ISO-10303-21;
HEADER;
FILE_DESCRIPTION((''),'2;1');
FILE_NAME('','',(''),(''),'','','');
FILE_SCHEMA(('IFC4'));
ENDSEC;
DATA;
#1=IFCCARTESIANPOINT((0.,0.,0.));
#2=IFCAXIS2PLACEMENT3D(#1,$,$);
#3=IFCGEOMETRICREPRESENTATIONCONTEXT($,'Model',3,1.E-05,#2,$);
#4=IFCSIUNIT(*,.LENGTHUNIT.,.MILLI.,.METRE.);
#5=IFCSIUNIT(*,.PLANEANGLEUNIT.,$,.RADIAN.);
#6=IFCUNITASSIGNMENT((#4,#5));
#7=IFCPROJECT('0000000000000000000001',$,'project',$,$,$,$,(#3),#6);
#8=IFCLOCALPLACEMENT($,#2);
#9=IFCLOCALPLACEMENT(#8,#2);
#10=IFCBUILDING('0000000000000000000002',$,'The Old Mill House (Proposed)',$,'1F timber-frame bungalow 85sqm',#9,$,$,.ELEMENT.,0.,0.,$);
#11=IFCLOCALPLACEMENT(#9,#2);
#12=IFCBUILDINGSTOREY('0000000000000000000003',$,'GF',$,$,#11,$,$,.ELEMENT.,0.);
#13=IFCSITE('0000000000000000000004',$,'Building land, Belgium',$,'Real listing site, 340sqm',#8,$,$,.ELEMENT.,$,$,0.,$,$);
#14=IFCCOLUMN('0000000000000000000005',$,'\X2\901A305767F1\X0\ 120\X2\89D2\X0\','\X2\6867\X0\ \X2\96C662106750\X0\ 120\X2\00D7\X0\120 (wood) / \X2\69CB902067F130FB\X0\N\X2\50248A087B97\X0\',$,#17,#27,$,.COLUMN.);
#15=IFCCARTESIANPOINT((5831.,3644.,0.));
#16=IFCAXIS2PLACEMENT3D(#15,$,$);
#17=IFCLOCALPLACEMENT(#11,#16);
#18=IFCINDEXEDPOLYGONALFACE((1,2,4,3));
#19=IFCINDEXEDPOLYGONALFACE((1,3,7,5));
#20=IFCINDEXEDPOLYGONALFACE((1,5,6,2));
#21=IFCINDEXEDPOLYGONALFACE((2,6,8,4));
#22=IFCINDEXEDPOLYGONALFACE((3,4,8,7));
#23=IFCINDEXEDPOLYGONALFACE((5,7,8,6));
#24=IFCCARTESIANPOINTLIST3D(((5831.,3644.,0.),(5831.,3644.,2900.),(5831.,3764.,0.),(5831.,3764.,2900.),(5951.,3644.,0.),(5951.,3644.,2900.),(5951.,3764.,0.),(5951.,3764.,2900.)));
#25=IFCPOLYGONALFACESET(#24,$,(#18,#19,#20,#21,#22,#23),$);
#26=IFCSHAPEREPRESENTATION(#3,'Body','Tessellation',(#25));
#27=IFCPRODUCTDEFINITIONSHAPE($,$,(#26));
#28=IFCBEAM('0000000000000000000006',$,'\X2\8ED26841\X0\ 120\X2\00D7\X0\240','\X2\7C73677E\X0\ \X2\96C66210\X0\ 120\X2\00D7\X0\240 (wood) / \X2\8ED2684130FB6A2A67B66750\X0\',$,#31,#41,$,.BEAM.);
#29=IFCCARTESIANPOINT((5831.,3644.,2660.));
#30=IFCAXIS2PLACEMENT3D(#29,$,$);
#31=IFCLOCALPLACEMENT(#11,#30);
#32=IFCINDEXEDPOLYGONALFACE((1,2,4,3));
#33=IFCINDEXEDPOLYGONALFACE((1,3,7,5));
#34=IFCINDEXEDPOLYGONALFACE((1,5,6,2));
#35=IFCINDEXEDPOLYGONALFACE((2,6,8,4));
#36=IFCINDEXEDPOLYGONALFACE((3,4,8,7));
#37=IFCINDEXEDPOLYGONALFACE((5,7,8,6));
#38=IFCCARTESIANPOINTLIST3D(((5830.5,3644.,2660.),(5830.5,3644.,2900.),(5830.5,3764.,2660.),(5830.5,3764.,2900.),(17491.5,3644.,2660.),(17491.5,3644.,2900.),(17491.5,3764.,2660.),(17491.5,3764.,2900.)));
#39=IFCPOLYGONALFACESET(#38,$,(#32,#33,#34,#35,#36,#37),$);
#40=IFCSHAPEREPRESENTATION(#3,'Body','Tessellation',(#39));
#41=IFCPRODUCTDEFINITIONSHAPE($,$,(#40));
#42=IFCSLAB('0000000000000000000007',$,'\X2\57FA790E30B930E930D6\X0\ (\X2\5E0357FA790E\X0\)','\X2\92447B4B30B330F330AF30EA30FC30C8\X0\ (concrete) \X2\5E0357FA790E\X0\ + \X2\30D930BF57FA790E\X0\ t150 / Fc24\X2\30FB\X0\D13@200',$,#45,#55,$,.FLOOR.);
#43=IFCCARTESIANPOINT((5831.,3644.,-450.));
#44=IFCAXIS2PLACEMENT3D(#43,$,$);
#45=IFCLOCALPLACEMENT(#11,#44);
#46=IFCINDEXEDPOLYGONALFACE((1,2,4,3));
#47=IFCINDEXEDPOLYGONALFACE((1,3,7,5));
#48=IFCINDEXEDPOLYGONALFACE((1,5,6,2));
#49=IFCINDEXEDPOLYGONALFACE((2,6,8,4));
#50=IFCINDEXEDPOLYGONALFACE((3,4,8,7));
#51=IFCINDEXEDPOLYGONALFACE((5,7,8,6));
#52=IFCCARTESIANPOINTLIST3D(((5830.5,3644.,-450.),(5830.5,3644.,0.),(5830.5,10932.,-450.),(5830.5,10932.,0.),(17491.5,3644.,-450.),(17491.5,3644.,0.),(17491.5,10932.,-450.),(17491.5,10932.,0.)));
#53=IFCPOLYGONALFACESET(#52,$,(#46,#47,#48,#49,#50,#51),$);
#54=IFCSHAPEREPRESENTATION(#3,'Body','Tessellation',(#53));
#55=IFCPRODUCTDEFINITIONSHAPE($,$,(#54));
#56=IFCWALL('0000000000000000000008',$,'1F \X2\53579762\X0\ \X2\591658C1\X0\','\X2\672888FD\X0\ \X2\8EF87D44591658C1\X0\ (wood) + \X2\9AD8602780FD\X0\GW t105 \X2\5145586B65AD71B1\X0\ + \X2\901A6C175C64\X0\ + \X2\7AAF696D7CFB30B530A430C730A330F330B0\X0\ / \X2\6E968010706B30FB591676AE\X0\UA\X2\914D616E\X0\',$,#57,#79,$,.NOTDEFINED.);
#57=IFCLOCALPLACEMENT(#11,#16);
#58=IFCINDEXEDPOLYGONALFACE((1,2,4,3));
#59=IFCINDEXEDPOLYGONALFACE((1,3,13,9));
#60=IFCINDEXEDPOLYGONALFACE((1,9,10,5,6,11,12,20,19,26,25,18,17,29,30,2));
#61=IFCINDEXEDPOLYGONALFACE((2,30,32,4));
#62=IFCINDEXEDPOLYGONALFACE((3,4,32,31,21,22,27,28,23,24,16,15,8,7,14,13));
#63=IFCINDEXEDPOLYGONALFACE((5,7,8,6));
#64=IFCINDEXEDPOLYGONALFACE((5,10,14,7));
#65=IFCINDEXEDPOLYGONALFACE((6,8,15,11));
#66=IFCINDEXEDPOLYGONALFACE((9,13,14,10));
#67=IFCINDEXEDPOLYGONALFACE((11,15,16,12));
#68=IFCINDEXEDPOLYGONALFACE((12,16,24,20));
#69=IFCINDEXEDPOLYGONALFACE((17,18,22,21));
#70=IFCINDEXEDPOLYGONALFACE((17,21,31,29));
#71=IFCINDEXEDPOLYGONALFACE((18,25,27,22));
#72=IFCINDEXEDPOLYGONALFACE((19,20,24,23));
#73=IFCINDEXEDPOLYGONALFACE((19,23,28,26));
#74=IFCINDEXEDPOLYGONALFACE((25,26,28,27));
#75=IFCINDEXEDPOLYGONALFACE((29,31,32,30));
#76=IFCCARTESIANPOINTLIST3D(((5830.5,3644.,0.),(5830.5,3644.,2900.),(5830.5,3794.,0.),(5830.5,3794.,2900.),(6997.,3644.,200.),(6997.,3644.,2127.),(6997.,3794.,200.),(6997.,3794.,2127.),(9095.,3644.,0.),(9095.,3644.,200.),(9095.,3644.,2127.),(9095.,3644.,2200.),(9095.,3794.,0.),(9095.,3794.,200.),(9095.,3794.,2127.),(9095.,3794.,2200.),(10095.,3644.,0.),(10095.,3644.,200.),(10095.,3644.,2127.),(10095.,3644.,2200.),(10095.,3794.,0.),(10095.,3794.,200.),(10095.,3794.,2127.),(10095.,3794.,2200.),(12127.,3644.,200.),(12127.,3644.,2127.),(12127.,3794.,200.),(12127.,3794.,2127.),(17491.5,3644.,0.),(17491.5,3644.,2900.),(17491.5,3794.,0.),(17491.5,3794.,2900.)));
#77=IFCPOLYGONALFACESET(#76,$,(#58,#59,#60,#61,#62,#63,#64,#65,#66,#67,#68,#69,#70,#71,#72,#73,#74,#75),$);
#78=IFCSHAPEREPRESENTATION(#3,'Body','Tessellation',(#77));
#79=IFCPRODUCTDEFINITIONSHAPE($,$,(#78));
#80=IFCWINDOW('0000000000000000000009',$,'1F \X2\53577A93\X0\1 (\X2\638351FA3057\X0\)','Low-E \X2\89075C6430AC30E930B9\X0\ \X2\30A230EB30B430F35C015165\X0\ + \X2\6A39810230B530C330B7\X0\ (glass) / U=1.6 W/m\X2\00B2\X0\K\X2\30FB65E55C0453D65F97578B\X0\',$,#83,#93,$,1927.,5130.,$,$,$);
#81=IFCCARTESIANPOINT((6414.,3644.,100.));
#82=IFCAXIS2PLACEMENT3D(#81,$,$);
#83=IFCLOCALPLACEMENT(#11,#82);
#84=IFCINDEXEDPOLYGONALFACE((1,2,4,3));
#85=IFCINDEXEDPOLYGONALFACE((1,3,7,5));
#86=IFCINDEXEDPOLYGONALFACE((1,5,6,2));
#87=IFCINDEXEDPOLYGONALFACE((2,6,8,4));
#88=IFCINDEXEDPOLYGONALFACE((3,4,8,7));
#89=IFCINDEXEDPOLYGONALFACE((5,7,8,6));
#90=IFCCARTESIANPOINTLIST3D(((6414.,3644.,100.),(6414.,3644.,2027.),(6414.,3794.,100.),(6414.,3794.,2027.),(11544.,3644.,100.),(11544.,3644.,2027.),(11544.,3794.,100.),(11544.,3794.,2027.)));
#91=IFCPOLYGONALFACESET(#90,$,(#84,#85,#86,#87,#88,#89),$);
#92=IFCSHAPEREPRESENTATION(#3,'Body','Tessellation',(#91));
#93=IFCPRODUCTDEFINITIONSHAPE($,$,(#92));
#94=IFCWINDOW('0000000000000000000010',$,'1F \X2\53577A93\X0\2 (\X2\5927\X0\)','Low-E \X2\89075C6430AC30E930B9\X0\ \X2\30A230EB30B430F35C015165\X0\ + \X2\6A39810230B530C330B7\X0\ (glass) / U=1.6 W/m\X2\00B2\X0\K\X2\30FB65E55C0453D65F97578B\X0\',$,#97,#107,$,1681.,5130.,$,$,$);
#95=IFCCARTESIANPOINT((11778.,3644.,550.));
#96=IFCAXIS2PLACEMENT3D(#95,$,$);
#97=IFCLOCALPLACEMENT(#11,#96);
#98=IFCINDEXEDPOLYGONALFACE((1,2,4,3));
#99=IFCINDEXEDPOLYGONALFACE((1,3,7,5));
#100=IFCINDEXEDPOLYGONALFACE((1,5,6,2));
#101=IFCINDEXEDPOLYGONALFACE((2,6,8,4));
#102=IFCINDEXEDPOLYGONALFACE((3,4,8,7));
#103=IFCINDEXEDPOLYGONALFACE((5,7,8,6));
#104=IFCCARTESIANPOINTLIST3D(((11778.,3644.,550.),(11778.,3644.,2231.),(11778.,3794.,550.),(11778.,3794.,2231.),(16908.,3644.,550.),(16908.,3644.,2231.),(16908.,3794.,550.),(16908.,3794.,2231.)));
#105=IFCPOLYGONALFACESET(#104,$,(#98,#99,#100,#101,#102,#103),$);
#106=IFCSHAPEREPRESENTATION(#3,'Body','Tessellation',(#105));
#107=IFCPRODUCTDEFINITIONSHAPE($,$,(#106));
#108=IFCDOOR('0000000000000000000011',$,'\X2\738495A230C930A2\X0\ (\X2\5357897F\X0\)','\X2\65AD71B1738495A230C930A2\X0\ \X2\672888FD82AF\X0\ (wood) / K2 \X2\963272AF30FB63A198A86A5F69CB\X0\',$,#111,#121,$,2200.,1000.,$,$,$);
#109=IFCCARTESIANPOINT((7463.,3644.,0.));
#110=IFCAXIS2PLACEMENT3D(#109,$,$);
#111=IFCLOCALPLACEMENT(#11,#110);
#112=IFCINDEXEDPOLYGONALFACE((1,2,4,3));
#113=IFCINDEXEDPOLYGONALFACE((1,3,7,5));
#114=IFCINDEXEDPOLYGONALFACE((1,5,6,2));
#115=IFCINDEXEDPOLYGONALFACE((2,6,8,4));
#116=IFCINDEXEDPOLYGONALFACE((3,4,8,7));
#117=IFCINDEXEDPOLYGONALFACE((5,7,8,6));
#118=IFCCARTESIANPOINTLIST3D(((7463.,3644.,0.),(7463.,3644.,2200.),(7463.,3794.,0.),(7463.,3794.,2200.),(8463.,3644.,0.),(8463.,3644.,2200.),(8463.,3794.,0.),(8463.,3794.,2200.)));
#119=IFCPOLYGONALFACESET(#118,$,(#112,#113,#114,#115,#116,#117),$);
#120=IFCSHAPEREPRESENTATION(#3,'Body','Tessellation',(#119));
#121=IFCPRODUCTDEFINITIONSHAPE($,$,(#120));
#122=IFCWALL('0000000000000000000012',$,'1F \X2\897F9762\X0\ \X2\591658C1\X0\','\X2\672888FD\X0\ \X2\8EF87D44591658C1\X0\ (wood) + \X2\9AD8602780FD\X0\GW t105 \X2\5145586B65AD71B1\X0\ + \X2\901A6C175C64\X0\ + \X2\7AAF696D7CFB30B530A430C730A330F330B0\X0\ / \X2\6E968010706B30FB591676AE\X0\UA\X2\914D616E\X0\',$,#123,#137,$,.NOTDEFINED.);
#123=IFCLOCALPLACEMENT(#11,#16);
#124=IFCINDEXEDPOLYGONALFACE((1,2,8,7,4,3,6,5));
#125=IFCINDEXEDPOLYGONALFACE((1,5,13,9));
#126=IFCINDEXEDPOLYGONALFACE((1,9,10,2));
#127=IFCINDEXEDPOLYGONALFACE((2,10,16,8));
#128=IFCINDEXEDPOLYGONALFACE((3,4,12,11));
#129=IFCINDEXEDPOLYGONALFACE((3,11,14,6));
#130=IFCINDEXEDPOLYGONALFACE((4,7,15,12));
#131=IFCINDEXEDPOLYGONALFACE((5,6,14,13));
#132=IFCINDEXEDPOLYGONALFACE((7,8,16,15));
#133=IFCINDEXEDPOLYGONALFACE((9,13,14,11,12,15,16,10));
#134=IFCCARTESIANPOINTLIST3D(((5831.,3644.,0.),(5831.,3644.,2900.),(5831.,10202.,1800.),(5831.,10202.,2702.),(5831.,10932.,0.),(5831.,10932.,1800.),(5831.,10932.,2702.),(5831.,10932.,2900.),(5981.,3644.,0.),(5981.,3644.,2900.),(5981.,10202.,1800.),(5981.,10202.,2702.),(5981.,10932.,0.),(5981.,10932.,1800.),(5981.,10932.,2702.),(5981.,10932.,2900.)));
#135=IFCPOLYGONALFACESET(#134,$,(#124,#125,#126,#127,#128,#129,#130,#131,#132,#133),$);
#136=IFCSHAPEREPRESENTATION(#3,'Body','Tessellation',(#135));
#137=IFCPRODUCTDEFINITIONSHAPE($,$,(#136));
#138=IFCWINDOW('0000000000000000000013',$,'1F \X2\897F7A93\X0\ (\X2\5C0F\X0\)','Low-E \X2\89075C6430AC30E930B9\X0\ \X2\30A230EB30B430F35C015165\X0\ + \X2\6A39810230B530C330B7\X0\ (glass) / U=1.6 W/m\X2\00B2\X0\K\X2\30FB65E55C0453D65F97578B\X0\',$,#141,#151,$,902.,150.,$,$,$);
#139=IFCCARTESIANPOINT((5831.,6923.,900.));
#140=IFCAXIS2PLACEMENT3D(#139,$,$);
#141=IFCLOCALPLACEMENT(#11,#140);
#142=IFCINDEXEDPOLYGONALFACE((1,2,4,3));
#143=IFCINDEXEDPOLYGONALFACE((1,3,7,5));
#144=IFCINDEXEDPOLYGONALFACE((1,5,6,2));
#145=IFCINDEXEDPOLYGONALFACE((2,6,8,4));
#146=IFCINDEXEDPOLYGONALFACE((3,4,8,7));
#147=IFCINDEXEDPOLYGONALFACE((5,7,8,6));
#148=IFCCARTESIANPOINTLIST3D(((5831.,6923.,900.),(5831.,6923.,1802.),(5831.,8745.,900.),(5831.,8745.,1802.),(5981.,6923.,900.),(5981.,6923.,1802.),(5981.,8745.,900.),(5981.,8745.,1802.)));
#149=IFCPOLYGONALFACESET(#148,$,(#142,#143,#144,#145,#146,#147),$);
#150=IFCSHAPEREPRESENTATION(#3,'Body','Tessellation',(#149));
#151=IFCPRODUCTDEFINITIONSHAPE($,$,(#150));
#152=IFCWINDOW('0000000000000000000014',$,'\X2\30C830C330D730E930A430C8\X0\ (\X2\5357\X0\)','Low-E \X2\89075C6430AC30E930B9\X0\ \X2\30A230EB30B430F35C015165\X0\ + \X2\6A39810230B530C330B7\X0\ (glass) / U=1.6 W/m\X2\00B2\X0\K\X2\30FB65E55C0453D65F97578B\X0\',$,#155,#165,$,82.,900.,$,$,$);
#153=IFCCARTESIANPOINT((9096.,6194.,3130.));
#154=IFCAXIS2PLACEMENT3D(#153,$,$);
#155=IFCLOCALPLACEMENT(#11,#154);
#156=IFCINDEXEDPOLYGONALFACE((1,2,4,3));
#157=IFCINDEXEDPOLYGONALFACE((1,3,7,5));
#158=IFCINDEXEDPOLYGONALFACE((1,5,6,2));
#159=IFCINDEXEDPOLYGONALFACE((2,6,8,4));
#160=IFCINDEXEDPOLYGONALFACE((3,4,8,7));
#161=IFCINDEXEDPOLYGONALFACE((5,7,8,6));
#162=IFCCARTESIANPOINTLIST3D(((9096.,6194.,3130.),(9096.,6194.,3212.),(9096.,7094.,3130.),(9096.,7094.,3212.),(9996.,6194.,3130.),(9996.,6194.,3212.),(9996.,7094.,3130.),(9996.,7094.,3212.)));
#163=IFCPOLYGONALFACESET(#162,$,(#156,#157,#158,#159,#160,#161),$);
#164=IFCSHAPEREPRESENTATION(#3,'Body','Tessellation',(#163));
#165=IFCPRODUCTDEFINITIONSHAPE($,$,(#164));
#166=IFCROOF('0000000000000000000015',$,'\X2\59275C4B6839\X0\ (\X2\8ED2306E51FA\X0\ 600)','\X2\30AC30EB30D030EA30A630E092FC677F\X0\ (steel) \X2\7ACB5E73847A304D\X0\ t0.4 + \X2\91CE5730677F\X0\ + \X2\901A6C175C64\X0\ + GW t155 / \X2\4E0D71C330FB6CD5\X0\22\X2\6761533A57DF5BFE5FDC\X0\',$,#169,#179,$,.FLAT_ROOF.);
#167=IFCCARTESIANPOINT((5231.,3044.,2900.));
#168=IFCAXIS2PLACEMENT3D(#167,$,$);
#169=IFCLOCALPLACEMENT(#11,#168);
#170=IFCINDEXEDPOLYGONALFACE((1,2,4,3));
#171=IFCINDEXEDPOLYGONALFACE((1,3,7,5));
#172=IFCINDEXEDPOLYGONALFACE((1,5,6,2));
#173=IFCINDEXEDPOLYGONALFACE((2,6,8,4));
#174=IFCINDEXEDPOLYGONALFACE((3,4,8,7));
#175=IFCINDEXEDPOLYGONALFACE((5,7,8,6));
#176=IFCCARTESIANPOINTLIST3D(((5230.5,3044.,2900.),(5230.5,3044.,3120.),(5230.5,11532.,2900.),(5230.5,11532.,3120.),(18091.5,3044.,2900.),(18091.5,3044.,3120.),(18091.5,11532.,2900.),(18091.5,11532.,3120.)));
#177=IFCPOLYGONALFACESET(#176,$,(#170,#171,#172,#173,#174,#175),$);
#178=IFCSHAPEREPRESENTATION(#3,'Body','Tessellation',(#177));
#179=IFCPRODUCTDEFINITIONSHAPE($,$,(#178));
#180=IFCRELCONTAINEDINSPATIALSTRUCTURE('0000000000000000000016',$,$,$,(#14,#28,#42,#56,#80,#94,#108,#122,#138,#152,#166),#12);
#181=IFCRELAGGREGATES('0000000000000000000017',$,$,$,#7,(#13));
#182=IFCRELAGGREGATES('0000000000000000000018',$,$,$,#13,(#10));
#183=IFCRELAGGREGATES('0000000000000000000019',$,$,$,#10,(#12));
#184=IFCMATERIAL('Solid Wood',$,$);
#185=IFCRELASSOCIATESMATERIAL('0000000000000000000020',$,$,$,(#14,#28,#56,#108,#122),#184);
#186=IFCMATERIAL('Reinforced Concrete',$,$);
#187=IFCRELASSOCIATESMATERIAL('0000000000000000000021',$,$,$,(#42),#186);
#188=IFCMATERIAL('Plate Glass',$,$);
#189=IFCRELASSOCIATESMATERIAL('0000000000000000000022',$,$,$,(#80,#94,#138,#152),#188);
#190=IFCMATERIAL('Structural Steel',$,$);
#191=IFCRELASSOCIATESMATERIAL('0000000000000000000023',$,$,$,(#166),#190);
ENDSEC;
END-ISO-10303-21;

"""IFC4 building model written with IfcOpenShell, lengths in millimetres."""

from ifc_helpers import new_model, si_unit, frame, frame_2d, origin, place, context, project, spatial, rectangle, extrude, material, element, fill, save


model = new_model("IFC4")

# Units and contexts
model_context = context("Model", 3, precision=1e-05, world=origin())
ifc_project = project(units=[si_unit("LENGTHUNIT", "METRE", prefix="MILLI"), si_unit("PLANEANGLEUNIT", "RADIAN")], contexts=[model_context])

# Site, building, storey
site_placement = place(None, origin())
site = spatial("IfcSite", under=ifc_project, at=site_placement, Name="Building land, Belgium", ObjectType="Real listing site, 340sqm", CompositionType="ELEMENT", RefElevation=0.0)
building_placement = place(site_placement, origin())
building = spatial("IfcBuilding", under=site, at=building_placement, Name="The Old Mill House (Proposed)", ObjectType="1F timber-frame bungalow 85sqm", CompositionType="ELEMENT", ElevationOfRefHeight=0.0, ElevationOfTerrain=0.0)
storey_placement = place(building_placement, origin())
storey = spatial("IfcBuildingStorey", under=building, at=storey_placement, Name="GF", CompositionType="ELEMENT", Elevation=0.0)

# Column
ifc_material_1 = material(Name="Solid Wood")
column_1_placement = place(storey_placement, frame((5831.0, 3644.0, 0.0)))
element("IfcColumn", 1, at=column_1_placement, inside=storey, material=ifc_material_1, Name="通し柱 120角", Description="桧 集成材 120×120 (wood) / 構造柱・N値計算", PredefinedType="COLUMN", context=model_context, shape_type="SweptSolid", body=[
    extrude(rectangle(XDim=120.0, YDim=120.0, at=frame_2d((60.0, 60.0))), frame((5831.0, 3644.0, 0.0)), (0.0, 0.0, 1.0), 2900.0),
])

# Beam
beam_1_placement = place(storey_placement, frame((5831.0, 3644.0, 2660.0)))
element("IfcBeam", 2, at=beam_1_placement, inside=storey, material=ifc_material_1, Name="軒桁 120×240", Description="米松 集成 120×240 (wood) / 軒桁・横架材", PredefinedType="BEAM", context=model_context, shape_type="SweptSolid", body=[
    extrude(rectangle(XDim=11661.0, YDim=120.0, at=frame_2d((5830.0, 60.0))), frame((5831.0, 3644.0, 2660.0)), (0.0, 0.0, 1.0), 240.0),
])

# Slab
ifc_material_2 = material(Name="Reinforced Concrete")
slab_1_placement = place(storey_placement, frame((5831.0, 3644.0, -450.0)))
element("IfcSlab", 3, at=slab_1_placement, inside=storey, material=ifc_material_2, Name="基礎スラブ (布基礎)", Description="鉄筋コンクリート (concrete) 布基礎 + ベタ基礎 t150 / Fc24・D13@200", PredefinedType="FLOOR", context=model_context, shape_type="SweptSolid", body=[
    extrude(rectangle(XDim=11661.0, YDim=7288.0, at=frame_2d((5830.0, 3644.0))), frame((5831.0, 3644.0, -450.0)), (0.0, 0.0, 1.0), 450.0),
])

# Wall, openings, windows, door
wall_1_placement = place(storey_placement, frame((5831.0, 3644.0, 0.0)))
wall_1 = element("IfcWall", 4, at=wall_1_placement, inside=storey, material=ifc_material_1, Name="1F 南面 外壁", Description="木製 軸組外壁 (wood) + 高性能GW t105 充填断熱 + 通気層 + 窯業系サイディング / 準耐火・外皮UA配慮", PredefinedType="NOTDEFINED", context=model_context, shape_type="SweptSolid", body=[
    extrude(rectangle(XDim=11661.0, YDim=150.0, at=frame_2d((5830.0, 75.0))), frame((5831.0, 3644.0, 0.0)), (0.0, 0.0, 1.0), 2900.0),
])
opening_1_placement = place(storey_placement, frame((6414.0, 3644.0, 100.0)))
opening_1 = element("IfcOpeningElement", 5, at=opening_1_placement, cuts=wall_1, PredefinedType="NOTDEFINED", context=model_context, shape_type="SweptSolid", body=[
    extrude(rectangle(XDim=5130.0, YDim=150.0, at=frame_2d((2565.0, 75.0))), frame((6414.0, 3644.0, 100.0)), (0.0, 0.0, 1.0), 1927.0),
])
opening_2_placement = place(storey_placement, frame((11778.0, 3644.0, 550.0)))
opening_2 = element("IfcOpeningElement", 6, at=opening_2_placement, cuts=wall_1, PredefinedType="NOTDEFINED", context=model_context, shape_type="SweptSolid", body=[
    extrude(rectangle(XDim=5130.0, YDim=150.0, at=frame_2d((2565.0, 75.0))), frame((11778.0, 3644.0, 550.0)), (0.0, 0.0, 1.0), 1681.0),
])
opening_3_placement = place(storey_placement, frame((7463.0, 3644.0, 0.0)))
opening_3 = element("IfcOpeningElement", 7, at=opening_3_placement, cuts=wall_1, PredefinedType="NOTDEFINED", context=model_context, shape_type="SweptSolid", body=[
    extrude(rectangle(XDim=1000.0, YDim=150.0, at=frame_2d((500.0, 75.0))), frame((7463.0, 3644.0, 0.0)), (0.0, 0.0, 1.0), 2200.0),
])
ifc_material_3 = material(Name="Plate Glass")
window_1_placement = place(storey_placement, frame((6414.0, 3644.0, 100.0)))
window_1 = element("IfcWindow", 8, at=window_1_placement, inside=storey, material=ifc_material_3, Name="1F 南窓1 (掃出し)", Description="Low-E 複層ガラス アルゴン封入 + 樹脂サッシ (glass) / U=1.6 W/m²K・日射取得型", OverallHeight=1927.0, OverallWidth=5130.0, context=model_context, shape_type="SweptSolid", body=[
    extrude(rectangle(XDim=5130.0, YDim=150.0, at=frame_2d((2565.0, 75.0))), frame((6414.0, 3644.0, 100.0)), (0.0, 0.0, 1.0), 1927.0),
])
fill(opening_1, window_1)
window_2_placement = place(storey_placement, frame((11778.0, 3644.0, 550.0)))
window_2 = element("IfcWindow", 9, at=window_2_placement, inside=storey, material=ifc_material_3, Name="1F 南窓2 (大)", Description="Low-E 複層ガラス アルゴン封入 + 樹脂サッシ (glass) / U=1.6 W/m²K・日射取得型", OverallHeight=1681.0, OverallWidth=5130.0, context=model_context, shape_type="SweptSolid", body=[
    extrude(rectangle(XDim=5130.0, YDim=150.0, at=frame_2d((2565.0, 75.0))), frame((11778.0, 3644.0, 550.0)), (0.0, 0.0, 1.0), 1681.0),
])
fill(opening_2, window_2)
door_placement = place(storey_placement, frame((7463.0, 3644.0, 0.0)))
door = element("IfcDoor", 10, at=door_placement, inside=storey, material=ifc_material_1, Name="玄関ドア (南西)", Description="断熱玄関ドア 木製芯 (wood) / K2 防犯・採風機構", OverallHeight=2200.0, OverallWidth=1000.0, context=model_context, shape_type="SweptSolid", body=[
    extrude(rectangle(XDim=1000.0, YDim=150.0, at=frame_2d((500.0, 75.0))), frame((7463.0, 3644.0, 0.0)), (0.0, 0.0, 1.0), 2200.0),
])
fill(opening_3, door)

# Wall, opening, window
wall_2_placement = place(storey_placement, frame((5831.0, 3644.0, 0.0)))
wall_2 = element("IfcWall", 11, at=wall_2_placement, inside=storey, material=ifc_material_1, Name="1F 西面 外壁", Description="木製 軸組外壁 (wood) + 高性能GW t105 充填断熱 + 通気層 + 窯業系サイディング / 準耐火・外皮UA配慮", PredefinedType="NOTDEFINED", context=model_context, shape_type="SweptSolid", body=[
    extrude(rectangle(XDim=150.0, YDim=7288.0, at=frame_2d((75.0, 3644.0))), frame((5831.0, 3644.0, 0.0)), (0.0, 0.0, 1.0), 2900.0),
])
opening_4_placement = place(storey_placement, frame((5831.0, 6923.0, 900.0)))
opening_4 = element("IfcOpeningElement", 12, at=opening_4_placement, cuts=wall_2, PredefinedType="NOTDEFINED", context=model_context, shape_type="SweptSolid", body=[
    extrude(rectangle(XDim=150.0, YDim=1822.0, at=frame_2d((75.0, 911.0))), frame((5831.0, 6923.0, 900.0)), (0.0, 0.0, 1.0), 902.0),
])
window_3_placement = place(storey_placement, frame((5831.0, 6923.0, 900.0)))
window_3 = element("IfcWindow", 13, at=window_3_placement, inside=storey, material=ifc_material_3, Name="1F 西窓 (小)", Description="Low-E 複層ガラス アルゴン封入 + 樹脂サッシ (glass) / U=1.6 W/m²K・日射取得型", OverallHeight=902.0, OverallWidth=150.0, context=model_context, shape_type="SweptSolid", body=[
    extrude(rectangle(XDim=150.0, YDim=1822.0, at=frame_2d((75.0, 911.0))), frame((5831.0, 6923.0, 900.0)), (0.0, 0.0, 1.0), 902.0),
])
fill(opening_4, window_3)

# Window
window_4_placement = place(storey_placement, frame((9096.0, 6194.0, 3130.0)))
element("IfcWindow", 14, at=window_4_placement, inside=storey, material=ifc_material_3, Name="トップライト (南)", Description="Low-E 複層ガラス アルゴン封入 + 樹脂サッシ (glass) / U=1.6 W/m²K・日射取得型", OverallHeight=82.0, OverallWidth=900.0, context=model_context, shape_type="SweptSolid", body=[
    extrude(rectangle(XDim=900.0, YDim=900.0, at=frame_2d((450.0, 450.0))), frame((9096.0, 6194.0, 3130.0)), (0.0, 0.0, 1.0), 82.0),
])

# Roof
ifc_material_4 = material(Name="Structural Steel")
roof_placement = place(storey_placement, frame((5231.0, 3044.0, 2900.0)))
element("IfcRoof", 15, at=roof_placement, inside=storey, material=ifc_material_4, Name="大屋根 (軒の出 600)", Description="ガルバリウム鋼板 (steel) 立平葺き t0.4 + 野地板 + 通気層 + GW t155 / 不燃・法22条区域対応", PredefinedType="FLAT_ROOF", context=model_context, shape_type="SweptSolid", body=[
    extrude(rectangle(XDim=12861.0, YDim=8488.0, at=frame_2d((6430.0, 4244.0))), frame((5231.0, 3044.0, 2900.0)), (0.0, 0.0, 1.0), 220.0),
])

save(model, "model.ifc")
